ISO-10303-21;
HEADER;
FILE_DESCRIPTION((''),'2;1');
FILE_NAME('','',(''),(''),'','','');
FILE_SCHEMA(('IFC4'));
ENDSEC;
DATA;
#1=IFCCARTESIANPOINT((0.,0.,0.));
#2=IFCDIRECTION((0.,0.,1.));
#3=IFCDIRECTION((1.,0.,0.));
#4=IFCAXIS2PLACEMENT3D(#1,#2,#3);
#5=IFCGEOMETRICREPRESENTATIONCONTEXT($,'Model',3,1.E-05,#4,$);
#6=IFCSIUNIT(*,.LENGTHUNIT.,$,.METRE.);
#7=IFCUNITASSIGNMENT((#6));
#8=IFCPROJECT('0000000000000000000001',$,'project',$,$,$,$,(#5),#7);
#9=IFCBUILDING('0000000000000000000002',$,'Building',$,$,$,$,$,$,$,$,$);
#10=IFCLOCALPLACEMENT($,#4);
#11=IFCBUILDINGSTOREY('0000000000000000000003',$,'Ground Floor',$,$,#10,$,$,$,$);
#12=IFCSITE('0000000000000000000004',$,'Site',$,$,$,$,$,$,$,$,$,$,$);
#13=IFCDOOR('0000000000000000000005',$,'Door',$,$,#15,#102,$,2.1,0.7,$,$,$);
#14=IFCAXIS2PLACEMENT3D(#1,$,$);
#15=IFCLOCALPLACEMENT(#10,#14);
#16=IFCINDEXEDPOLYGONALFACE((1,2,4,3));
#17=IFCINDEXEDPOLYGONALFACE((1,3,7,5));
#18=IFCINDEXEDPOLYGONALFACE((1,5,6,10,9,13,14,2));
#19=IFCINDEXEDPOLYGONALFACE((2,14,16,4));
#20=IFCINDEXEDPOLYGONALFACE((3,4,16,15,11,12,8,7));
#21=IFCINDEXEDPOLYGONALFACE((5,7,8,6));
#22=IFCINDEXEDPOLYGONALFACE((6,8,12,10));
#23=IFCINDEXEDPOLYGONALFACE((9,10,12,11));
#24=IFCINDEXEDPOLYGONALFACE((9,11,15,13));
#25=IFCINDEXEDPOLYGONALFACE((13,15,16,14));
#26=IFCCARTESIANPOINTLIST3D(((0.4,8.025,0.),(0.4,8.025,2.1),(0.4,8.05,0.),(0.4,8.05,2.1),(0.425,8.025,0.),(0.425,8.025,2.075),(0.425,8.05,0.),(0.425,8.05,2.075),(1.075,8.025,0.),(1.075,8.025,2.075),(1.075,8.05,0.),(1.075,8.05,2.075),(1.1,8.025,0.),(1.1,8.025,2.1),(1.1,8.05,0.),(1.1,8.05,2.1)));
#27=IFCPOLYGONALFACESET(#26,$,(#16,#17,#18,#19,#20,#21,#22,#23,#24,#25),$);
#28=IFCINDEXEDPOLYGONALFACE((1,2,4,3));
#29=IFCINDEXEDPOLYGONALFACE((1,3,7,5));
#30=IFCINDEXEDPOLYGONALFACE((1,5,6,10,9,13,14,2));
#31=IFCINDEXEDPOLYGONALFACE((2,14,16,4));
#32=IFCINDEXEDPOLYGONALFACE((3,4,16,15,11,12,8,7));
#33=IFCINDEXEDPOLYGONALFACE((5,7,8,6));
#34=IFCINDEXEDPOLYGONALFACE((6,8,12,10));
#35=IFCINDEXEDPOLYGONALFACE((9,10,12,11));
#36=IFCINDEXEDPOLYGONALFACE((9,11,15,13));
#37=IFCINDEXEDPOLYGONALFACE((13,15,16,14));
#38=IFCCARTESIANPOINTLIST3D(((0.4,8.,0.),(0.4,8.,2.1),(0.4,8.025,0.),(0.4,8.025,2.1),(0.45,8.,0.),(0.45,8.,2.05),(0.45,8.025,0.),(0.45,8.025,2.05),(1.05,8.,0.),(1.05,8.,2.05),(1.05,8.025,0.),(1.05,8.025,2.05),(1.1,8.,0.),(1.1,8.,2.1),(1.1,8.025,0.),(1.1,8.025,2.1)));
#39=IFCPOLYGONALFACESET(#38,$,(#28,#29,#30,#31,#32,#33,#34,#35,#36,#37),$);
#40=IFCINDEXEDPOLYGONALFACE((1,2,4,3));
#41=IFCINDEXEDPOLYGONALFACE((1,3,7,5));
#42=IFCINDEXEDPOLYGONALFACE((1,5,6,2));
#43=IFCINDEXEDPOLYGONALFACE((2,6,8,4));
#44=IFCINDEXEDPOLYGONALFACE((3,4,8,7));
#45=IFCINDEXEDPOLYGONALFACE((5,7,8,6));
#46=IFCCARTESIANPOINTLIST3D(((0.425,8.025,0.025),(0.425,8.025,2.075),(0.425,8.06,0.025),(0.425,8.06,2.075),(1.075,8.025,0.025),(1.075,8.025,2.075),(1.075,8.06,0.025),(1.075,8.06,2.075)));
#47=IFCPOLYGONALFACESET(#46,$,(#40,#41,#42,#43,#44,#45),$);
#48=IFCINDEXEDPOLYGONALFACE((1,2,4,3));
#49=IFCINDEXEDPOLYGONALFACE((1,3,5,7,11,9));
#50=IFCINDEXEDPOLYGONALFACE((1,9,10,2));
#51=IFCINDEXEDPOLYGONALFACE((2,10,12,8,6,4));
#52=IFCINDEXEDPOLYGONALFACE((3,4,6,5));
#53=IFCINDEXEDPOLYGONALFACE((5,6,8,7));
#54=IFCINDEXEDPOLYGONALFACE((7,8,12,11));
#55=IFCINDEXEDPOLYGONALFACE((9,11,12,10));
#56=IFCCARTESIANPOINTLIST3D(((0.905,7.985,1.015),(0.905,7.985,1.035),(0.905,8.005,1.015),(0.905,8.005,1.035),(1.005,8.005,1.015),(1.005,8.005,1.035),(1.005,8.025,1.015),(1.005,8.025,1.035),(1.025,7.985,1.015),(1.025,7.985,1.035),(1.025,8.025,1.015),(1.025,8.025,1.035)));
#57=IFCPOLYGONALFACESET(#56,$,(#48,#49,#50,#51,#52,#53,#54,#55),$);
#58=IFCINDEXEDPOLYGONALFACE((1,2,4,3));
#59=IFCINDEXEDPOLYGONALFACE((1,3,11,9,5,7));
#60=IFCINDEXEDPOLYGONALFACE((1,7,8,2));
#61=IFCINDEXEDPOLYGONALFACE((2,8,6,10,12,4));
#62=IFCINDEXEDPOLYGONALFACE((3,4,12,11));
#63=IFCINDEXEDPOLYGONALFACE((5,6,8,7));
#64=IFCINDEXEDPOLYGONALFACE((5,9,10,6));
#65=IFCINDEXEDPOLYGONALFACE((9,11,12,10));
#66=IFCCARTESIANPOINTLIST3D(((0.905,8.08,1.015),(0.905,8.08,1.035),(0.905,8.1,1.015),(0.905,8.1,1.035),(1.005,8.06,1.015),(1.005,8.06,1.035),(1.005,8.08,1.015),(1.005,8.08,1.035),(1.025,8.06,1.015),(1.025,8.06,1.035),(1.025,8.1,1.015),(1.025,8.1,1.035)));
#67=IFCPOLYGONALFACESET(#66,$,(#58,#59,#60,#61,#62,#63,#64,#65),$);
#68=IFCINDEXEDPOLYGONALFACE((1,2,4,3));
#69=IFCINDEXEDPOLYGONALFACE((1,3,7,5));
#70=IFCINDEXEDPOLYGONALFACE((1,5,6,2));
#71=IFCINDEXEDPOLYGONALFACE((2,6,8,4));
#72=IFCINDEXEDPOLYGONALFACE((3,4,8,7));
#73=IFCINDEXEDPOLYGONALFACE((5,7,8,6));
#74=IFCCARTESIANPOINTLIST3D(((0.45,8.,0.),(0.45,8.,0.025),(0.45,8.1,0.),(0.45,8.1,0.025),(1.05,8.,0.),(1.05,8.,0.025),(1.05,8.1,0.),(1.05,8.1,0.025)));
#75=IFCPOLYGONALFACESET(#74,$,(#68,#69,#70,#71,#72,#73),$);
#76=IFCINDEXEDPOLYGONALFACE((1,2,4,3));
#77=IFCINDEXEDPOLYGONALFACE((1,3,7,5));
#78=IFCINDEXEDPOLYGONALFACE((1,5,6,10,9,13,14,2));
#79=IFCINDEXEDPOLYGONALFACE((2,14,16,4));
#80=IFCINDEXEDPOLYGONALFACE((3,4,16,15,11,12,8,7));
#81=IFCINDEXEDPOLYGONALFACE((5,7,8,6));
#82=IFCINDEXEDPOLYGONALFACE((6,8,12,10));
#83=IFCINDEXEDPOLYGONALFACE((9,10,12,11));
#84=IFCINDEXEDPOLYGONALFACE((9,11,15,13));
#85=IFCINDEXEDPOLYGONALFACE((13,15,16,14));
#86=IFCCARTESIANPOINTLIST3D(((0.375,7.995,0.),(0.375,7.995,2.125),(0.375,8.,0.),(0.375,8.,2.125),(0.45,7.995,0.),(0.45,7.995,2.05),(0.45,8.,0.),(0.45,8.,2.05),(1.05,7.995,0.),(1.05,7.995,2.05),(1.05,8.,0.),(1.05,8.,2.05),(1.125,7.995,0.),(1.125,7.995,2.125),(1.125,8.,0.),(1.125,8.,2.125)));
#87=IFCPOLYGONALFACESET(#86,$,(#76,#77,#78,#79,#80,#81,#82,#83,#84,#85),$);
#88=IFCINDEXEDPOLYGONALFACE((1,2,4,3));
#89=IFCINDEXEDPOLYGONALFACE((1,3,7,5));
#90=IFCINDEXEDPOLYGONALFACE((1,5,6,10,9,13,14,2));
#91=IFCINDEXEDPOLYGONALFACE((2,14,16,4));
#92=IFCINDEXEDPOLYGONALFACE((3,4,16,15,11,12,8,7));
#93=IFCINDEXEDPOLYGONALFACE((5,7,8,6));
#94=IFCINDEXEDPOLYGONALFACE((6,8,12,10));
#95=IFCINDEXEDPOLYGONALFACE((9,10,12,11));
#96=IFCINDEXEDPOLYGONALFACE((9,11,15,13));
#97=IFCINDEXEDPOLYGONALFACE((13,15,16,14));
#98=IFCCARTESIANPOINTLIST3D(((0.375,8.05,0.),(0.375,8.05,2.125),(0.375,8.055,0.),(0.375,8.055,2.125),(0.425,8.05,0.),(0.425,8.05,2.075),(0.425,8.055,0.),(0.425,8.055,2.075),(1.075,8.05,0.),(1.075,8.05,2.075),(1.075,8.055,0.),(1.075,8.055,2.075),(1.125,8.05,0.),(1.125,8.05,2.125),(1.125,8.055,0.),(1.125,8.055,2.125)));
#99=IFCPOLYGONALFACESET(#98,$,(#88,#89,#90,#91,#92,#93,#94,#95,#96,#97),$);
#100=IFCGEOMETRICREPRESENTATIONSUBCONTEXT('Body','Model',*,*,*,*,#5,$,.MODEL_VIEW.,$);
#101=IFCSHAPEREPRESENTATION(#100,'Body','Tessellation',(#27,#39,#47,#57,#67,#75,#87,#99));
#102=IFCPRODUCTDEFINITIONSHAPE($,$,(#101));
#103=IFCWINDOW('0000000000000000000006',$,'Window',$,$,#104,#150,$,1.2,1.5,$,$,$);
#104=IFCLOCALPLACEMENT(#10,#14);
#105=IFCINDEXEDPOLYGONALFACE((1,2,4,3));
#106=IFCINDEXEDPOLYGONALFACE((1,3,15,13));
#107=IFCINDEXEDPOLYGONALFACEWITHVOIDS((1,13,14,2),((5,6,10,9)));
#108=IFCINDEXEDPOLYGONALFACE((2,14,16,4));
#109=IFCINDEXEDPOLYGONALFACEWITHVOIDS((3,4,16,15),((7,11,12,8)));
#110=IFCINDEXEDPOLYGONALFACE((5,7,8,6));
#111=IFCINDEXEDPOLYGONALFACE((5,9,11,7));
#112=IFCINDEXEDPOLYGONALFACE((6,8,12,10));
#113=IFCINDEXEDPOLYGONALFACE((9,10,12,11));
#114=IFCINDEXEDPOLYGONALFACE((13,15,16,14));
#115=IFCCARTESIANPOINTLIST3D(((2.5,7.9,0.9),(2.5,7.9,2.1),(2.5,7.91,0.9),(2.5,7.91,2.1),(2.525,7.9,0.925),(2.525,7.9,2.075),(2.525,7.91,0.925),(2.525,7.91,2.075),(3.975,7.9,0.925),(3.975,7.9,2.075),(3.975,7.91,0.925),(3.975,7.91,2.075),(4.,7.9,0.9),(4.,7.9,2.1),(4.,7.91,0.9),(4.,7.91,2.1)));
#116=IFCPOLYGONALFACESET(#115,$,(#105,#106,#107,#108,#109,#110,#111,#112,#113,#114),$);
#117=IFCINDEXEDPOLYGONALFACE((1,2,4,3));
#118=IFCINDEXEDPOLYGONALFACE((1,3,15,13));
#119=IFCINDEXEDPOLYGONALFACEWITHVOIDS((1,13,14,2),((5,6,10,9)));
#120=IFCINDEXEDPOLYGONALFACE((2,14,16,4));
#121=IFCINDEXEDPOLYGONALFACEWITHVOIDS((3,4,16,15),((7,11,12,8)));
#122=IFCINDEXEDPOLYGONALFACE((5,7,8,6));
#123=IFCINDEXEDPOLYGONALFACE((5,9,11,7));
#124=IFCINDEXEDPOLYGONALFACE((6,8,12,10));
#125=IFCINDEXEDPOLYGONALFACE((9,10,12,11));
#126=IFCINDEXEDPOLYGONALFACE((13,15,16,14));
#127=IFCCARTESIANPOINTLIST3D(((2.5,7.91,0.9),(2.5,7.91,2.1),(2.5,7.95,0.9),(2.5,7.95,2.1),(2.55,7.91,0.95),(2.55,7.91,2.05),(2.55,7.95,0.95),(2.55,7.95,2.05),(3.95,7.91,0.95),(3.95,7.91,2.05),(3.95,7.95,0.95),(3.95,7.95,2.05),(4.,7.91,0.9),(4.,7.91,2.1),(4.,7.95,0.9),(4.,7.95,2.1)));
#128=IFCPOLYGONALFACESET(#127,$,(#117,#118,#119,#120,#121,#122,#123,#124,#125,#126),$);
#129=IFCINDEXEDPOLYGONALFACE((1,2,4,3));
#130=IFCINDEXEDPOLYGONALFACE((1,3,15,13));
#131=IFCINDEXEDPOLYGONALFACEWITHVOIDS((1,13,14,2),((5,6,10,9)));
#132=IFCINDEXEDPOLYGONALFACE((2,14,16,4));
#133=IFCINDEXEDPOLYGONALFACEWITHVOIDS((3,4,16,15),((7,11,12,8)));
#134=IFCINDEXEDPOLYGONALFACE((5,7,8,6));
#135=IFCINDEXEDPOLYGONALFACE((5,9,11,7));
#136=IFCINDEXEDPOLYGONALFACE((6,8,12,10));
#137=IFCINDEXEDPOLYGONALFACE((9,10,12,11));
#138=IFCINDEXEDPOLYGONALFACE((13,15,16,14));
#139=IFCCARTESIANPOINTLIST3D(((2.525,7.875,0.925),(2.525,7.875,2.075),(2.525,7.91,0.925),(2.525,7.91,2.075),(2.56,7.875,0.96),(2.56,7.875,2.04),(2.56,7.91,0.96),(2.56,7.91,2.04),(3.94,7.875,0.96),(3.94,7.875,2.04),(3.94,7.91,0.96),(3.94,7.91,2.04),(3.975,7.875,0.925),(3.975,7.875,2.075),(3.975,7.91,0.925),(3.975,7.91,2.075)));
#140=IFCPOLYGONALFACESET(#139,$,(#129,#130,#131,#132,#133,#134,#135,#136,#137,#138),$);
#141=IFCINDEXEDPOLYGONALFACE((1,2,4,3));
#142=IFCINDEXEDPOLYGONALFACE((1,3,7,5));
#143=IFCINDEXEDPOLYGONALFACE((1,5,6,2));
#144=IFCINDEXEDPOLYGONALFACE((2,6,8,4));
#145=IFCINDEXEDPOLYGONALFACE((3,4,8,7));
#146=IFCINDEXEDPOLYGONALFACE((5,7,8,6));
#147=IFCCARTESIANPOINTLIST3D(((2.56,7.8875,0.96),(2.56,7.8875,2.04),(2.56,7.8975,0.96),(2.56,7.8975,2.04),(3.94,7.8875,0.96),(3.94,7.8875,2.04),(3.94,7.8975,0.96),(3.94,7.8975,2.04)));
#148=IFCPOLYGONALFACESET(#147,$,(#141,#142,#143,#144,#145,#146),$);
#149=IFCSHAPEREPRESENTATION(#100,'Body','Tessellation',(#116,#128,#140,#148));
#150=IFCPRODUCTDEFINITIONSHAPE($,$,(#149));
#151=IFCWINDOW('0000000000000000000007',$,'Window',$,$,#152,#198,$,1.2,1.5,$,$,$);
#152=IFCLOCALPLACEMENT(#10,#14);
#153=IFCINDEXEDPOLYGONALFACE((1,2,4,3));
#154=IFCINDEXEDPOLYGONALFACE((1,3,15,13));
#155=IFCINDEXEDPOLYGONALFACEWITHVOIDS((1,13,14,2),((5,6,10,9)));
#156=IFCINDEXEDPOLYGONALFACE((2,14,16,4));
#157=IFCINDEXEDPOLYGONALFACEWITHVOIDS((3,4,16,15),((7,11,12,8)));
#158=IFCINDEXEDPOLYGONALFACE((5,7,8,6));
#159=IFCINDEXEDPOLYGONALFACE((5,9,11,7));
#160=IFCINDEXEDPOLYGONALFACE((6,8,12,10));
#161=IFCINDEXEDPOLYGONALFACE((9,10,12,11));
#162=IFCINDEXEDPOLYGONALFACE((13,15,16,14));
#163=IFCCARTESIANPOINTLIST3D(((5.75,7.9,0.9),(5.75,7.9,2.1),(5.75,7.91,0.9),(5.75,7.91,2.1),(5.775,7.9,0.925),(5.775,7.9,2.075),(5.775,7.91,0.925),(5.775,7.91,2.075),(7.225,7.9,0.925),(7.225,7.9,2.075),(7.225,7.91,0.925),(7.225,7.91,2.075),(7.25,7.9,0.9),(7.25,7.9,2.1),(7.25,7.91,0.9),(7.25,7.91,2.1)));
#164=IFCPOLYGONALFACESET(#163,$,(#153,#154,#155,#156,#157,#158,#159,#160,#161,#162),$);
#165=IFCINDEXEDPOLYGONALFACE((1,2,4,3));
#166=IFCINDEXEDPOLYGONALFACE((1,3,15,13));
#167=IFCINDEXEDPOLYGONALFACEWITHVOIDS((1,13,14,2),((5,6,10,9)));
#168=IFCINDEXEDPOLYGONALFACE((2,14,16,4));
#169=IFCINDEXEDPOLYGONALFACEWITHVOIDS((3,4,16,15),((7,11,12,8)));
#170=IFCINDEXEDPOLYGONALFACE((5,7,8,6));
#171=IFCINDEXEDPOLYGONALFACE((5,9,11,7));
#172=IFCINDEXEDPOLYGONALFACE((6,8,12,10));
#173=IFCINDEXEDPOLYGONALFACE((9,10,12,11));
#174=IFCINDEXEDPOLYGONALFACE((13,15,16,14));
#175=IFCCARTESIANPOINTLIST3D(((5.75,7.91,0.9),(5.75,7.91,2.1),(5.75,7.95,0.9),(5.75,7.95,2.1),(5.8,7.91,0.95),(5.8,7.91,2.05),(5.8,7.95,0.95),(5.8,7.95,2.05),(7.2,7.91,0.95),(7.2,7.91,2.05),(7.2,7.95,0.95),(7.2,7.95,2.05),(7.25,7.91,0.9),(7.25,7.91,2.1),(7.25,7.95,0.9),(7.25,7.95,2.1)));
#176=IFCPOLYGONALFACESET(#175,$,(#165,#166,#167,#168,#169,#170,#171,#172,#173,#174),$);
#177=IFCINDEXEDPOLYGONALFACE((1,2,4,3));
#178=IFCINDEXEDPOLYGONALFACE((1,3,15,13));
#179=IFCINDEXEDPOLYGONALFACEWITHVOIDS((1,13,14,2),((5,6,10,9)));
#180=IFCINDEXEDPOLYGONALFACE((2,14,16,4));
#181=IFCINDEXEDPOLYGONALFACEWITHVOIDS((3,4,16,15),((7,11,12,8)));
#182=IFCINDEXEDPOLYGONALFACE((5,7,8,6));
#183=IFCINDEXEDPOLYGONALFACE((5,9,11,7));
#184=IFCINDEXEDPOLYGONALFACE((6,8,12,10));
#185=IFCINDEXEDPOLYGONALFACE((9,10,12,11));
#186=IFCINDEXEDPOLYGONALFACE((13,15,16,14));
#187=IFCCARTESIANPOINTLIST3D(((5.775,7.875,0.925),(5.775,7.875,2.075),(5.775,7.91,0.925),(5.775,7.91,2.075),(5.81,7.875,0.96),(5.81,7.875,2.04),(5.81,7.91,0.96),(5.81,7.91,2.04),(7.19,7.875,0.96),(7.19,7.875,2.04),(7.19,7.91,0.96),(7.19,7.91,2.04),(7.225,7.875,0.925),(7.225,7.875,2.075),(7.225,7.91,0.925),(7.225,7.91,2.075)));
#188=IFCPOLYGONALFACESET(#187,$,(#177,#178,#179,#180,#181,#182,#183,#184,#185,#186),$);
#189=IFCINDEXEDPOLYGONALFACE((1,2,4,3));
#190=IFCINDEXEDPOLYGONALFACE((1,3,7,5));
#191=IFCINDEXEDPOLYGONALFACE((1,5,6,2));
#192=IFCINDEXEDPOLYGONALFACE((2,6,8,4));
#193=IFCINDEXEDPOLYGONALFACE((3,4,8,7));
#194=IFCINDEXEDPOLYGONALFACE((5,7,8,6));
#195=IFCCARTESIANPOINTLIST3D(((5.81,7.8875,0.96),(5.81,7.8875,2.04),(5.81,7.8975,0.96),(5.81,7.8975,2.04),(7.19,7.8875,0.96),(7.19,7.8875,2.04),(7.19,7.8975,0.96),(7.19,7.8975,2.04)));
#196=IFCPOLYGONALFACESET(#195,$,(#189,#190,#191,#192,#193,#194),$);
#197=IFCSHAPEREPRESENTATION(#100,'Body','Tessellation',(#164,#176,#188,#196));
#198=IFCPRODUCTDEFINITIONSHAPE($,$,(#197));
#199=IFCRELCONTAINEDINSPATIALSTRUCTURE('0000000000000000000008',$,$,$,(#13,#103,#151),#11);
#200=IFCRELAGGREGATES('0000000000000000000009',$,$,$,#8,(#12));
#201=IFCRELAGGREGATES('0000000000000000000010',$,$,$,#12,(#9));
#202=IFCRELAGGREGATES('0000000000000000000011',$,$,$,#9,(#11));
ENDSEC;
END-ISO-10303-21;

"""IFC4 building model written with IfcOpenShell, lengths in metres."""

from ifc_helpers import new_model, si_unit, frame, origin_with_axes, place, context, subcontext, project, spatial, line, indexed_curve, outline, extrude, element, save


model = new_model("IFC4")

# Units and contexts
model_context = context("Model", 3, precision=1e-05, world=origin_with_axes())
body_context = subcontext(model_context, "Body", "Model", "MODEL_VIEW")
ifc_project = project(units=[si_unit("LENGTHUNIT", "METRE")], contexts=[model_context])

# Site, building, storey
site = spatial("IfcSite", under=ifc_project, Name="Site")
building = spatial("IfcBuilding", under=site, Name="Building")
storey_placement = place(None, origin_with_axes())
storey = spatial("IfcBuildingStorey", under=building, at=storey_placement, Name="Ground Floor")

# Door
door_1_placement = place(storey_placement, frame((0.4, 8.0, 0.0), z_axis=(0.0, 0.0, 1.0), x_axis=(1.0, 0.0, 0.0)))
element("IfcDoor", 1, at=door_1_placement, inside=storey, Name="Door", OverallHeight=2.1, OverallWidth=0.7, context=body_context, shape_type="SweptSolid", body=[
    extrude(outline(indexed_curve([(0.0, 0.0), (0.0, 2.1), (0.7, 2.1), (0.7, 0.0), (0.675, 0.0), (0.675, 2.075), (0.025, 2.075), (0.025, 0.0)], segments=[line(1, 2, 3, 4, 5, 6, 7, 8, 1)])), frame((0.0, 0.025, 0.0), z_axis=(0.0, -1.0, 0.0), x_axis=(1.0, 0.0, 0.0)), (0.0, 0.0, -1.0), 0.025),
    extrude(outline(indexed_curve([(0.0, 0.0), (0.0, 2.1), (0.7, 2.1), (0.7, 0.0), (0.65, 0.0), (0.65, 2.05), (0.05, 2.05), (0.05, 0.0)], segments=[line(1, 2, 3, 4, 5, 6, 7, 8, 1)])), frame((0.0, 0.0, 0.0), z_axis=(0.0, -1.0, 0.0), x_axis=(1.0, 0.0, 0.0)), (0.0, 0.0, -1.0), 0.025),
    extrude(outline(indexed_curve([(0.0, 0.0), (0.65, 0.0), (0.65, 0.035), (0.0, 0.035)], segments=[line(1, 2, 3, 4, 1)])), frame((0.025, 0.025, 0.025), z_axis=(0.0, 0.0, 1.0), x_axis=(1.0, 0.0, 0.0)), (0.0, 0.0, 1.0), 2.05),
    extrude(outline(indexed_curve([(0.0, 0.0), (0.0, -0.04), (-0.12, -0.04), (-0.12, -0.02), (-0.02, -0.02), (-0.02, 0.0)], segments=[line(1, 2, 3, 4, 5, 6, 1)])), frame((0.625, 0.025, 1.015), z_axis=(0.0, 0.0, 1.0), x_axis=(1.0, 0.0, 0.0)), (0.0, 0.0, 1.0), 0.02),
    extrude(outline(indexed_curve([(0.0, 0.0), (0.0, 0.04), (-0.12, 0.04), (-0.12, 0.02), (-0.02, 0.02), (-0.02, 0.0)], segments=[line(1, 2, 3, 4, 5, 6, 1)])), frame((0.625, 0.06, 1.015), z_axis=(0.0, 0.0, 1.0), x_axis=(1.0, 0.0, 0.0)), (0.0, 0.0, 1.0), 0.02),
    extrude(outline(indexed_curve([(0.0, 0.0), (0.6, 0.0), (0.6, 0.1), (0.0, 0.1)], segments=[line(1, 2, 3, 4, 1)])), frame((0.05, 0.0, 0.0), z_axis=(0.0, 0.0, 1.0), x_axis=(1.0, 0.0, 0.0)), (0.0, 0.0, 1.0), 0.025),
    extrude(outline(indexed_curve([(0.0, 0.0), (0.0, 2.125), (0.75, 2.125), (0.75, 0.0), (0.675, 0.0), (0.675, 2.05), (0.075, 2.05), (0.075, 0.0)], segments=[line(1, 2, 3, 4, 5, 6, 7, 8, 1)])), frame((-0.025, -0.005, 0.0), z_axis=(0.0, -1.0, 0.0), x_axis=(1.0, 0.0, 0.0)), (0.0, 0.0, -1.0), 0.005),
    extrude(outline(indexed_curve([(0.0, 0.0), (0.0, 2.125), (0.75, 2.125), (0.75, 0.0), (0.7, 0.0), (0.7, 2.075), (0.05, 2.075), (0.05, 0.0)], segments=[line(1, 2, 3, 4, 5, 6, 7, 8, 1)])), frame((-0.025, 0.05, 0.0), z_axis=(0.0, -1.0, 0.0), x_axis=(1.0, 0.0, 0.0)), (0.0, 0.0, -1.0), 0.005),
])

# Windows
for number, where, z_axis, x_axis, name in (
    (2, (4.0, 8.0, 0.9), (0.0, 0.0, 1.0), (-1.0, 0.0, 0.0), "Window"),
    (3, (7.25, 8.0, 0.9), (0.0, 0.0, 1.0), (-1.0, 0.0, 0.0), "Window"),
):
    element("IfcWindow", number, at=place(storey_placement, frame(where, z_axis=z_axis, x_axis=x_axis)), inside=storey, Name=name, OverallHeight=1.2, OverallWidth=1.5, context=body_context, shape_type="SweptSolid", body=[
        extrude(outline(indexed_curve([(0.0, 0.0), (1.5, 0.0), (1.5, 1.2), (0.0, 1.2)], segments=[line(1, 2, 3, 4, 1)]), holes=[indexed_curve([(0.025, 0.025), (1.475, 0.025), (1.475, 1.175), (0.025, 1.175)], segments=[line(1, 2, 3, 4, 1)])]), frame((0.0, 0.09, 0.0), z_axis=(0.0, -1.0, 0.0), x_axis=(1.0, 0.0, 0.0)), (0.0, 0.0, -1.0), 0.01),
        extrude(outline(indexed_curve([(0.0, 0.0), (1.5, 0.0), (1.5, 1.2), (0.0, 1.2)], segments=[line(1, 2, 3, 4, 1)]), holes=[indexed_curve([(0.05, 0.05), (1.45, 0.05), (1.45, 1.15), (0.05, 1.15)], segments=[line(1, 2, 3, 4, 1)])]), frame((0.0, 0.05, 0.0), z_axis=(0.0, -1.0, 0.0), x_axis=(1.0, 0.0, 0.0)), (0.0, 0.0, -1.0), 0.04),
        extrude(outline(indexed_curve([(0.0, 0.0), (1.45, 0.0), (1.45, 1.15), (0.0, 1.15)], segments=[line(1, 2, 3, 4, 1)]), holes=[indexed_curve([(0.035, 0.035), (1.415, 0.035), (1.415, 1.115), (0.035, 1.115)], segments=[line(1, 2, 3, 4, 1)])]), frame((0.025, 0.09, 0.025), z_axis=(0.0, -1.0, 0.0), x_axis=(1.0, 0.0, 0.0)), (0.0, 0.0, -1.0), 0.035),
        extrude(outline(indexed_curve([(0.035, 0.035), (1.415, 0.035), (1.415, 1.115), (0.035, 1.115)], segments=[line(1, 2, 3, 4, 1)])), frame((0.025, 0.1025, 0.025), z_axis=(0.0, -1.0, 0.0), x_axis=(1.0, 0.0, 0.0)), (0.0, 0.0, -1.0), 0.01),
    ])

save(model, "model.ifc")
